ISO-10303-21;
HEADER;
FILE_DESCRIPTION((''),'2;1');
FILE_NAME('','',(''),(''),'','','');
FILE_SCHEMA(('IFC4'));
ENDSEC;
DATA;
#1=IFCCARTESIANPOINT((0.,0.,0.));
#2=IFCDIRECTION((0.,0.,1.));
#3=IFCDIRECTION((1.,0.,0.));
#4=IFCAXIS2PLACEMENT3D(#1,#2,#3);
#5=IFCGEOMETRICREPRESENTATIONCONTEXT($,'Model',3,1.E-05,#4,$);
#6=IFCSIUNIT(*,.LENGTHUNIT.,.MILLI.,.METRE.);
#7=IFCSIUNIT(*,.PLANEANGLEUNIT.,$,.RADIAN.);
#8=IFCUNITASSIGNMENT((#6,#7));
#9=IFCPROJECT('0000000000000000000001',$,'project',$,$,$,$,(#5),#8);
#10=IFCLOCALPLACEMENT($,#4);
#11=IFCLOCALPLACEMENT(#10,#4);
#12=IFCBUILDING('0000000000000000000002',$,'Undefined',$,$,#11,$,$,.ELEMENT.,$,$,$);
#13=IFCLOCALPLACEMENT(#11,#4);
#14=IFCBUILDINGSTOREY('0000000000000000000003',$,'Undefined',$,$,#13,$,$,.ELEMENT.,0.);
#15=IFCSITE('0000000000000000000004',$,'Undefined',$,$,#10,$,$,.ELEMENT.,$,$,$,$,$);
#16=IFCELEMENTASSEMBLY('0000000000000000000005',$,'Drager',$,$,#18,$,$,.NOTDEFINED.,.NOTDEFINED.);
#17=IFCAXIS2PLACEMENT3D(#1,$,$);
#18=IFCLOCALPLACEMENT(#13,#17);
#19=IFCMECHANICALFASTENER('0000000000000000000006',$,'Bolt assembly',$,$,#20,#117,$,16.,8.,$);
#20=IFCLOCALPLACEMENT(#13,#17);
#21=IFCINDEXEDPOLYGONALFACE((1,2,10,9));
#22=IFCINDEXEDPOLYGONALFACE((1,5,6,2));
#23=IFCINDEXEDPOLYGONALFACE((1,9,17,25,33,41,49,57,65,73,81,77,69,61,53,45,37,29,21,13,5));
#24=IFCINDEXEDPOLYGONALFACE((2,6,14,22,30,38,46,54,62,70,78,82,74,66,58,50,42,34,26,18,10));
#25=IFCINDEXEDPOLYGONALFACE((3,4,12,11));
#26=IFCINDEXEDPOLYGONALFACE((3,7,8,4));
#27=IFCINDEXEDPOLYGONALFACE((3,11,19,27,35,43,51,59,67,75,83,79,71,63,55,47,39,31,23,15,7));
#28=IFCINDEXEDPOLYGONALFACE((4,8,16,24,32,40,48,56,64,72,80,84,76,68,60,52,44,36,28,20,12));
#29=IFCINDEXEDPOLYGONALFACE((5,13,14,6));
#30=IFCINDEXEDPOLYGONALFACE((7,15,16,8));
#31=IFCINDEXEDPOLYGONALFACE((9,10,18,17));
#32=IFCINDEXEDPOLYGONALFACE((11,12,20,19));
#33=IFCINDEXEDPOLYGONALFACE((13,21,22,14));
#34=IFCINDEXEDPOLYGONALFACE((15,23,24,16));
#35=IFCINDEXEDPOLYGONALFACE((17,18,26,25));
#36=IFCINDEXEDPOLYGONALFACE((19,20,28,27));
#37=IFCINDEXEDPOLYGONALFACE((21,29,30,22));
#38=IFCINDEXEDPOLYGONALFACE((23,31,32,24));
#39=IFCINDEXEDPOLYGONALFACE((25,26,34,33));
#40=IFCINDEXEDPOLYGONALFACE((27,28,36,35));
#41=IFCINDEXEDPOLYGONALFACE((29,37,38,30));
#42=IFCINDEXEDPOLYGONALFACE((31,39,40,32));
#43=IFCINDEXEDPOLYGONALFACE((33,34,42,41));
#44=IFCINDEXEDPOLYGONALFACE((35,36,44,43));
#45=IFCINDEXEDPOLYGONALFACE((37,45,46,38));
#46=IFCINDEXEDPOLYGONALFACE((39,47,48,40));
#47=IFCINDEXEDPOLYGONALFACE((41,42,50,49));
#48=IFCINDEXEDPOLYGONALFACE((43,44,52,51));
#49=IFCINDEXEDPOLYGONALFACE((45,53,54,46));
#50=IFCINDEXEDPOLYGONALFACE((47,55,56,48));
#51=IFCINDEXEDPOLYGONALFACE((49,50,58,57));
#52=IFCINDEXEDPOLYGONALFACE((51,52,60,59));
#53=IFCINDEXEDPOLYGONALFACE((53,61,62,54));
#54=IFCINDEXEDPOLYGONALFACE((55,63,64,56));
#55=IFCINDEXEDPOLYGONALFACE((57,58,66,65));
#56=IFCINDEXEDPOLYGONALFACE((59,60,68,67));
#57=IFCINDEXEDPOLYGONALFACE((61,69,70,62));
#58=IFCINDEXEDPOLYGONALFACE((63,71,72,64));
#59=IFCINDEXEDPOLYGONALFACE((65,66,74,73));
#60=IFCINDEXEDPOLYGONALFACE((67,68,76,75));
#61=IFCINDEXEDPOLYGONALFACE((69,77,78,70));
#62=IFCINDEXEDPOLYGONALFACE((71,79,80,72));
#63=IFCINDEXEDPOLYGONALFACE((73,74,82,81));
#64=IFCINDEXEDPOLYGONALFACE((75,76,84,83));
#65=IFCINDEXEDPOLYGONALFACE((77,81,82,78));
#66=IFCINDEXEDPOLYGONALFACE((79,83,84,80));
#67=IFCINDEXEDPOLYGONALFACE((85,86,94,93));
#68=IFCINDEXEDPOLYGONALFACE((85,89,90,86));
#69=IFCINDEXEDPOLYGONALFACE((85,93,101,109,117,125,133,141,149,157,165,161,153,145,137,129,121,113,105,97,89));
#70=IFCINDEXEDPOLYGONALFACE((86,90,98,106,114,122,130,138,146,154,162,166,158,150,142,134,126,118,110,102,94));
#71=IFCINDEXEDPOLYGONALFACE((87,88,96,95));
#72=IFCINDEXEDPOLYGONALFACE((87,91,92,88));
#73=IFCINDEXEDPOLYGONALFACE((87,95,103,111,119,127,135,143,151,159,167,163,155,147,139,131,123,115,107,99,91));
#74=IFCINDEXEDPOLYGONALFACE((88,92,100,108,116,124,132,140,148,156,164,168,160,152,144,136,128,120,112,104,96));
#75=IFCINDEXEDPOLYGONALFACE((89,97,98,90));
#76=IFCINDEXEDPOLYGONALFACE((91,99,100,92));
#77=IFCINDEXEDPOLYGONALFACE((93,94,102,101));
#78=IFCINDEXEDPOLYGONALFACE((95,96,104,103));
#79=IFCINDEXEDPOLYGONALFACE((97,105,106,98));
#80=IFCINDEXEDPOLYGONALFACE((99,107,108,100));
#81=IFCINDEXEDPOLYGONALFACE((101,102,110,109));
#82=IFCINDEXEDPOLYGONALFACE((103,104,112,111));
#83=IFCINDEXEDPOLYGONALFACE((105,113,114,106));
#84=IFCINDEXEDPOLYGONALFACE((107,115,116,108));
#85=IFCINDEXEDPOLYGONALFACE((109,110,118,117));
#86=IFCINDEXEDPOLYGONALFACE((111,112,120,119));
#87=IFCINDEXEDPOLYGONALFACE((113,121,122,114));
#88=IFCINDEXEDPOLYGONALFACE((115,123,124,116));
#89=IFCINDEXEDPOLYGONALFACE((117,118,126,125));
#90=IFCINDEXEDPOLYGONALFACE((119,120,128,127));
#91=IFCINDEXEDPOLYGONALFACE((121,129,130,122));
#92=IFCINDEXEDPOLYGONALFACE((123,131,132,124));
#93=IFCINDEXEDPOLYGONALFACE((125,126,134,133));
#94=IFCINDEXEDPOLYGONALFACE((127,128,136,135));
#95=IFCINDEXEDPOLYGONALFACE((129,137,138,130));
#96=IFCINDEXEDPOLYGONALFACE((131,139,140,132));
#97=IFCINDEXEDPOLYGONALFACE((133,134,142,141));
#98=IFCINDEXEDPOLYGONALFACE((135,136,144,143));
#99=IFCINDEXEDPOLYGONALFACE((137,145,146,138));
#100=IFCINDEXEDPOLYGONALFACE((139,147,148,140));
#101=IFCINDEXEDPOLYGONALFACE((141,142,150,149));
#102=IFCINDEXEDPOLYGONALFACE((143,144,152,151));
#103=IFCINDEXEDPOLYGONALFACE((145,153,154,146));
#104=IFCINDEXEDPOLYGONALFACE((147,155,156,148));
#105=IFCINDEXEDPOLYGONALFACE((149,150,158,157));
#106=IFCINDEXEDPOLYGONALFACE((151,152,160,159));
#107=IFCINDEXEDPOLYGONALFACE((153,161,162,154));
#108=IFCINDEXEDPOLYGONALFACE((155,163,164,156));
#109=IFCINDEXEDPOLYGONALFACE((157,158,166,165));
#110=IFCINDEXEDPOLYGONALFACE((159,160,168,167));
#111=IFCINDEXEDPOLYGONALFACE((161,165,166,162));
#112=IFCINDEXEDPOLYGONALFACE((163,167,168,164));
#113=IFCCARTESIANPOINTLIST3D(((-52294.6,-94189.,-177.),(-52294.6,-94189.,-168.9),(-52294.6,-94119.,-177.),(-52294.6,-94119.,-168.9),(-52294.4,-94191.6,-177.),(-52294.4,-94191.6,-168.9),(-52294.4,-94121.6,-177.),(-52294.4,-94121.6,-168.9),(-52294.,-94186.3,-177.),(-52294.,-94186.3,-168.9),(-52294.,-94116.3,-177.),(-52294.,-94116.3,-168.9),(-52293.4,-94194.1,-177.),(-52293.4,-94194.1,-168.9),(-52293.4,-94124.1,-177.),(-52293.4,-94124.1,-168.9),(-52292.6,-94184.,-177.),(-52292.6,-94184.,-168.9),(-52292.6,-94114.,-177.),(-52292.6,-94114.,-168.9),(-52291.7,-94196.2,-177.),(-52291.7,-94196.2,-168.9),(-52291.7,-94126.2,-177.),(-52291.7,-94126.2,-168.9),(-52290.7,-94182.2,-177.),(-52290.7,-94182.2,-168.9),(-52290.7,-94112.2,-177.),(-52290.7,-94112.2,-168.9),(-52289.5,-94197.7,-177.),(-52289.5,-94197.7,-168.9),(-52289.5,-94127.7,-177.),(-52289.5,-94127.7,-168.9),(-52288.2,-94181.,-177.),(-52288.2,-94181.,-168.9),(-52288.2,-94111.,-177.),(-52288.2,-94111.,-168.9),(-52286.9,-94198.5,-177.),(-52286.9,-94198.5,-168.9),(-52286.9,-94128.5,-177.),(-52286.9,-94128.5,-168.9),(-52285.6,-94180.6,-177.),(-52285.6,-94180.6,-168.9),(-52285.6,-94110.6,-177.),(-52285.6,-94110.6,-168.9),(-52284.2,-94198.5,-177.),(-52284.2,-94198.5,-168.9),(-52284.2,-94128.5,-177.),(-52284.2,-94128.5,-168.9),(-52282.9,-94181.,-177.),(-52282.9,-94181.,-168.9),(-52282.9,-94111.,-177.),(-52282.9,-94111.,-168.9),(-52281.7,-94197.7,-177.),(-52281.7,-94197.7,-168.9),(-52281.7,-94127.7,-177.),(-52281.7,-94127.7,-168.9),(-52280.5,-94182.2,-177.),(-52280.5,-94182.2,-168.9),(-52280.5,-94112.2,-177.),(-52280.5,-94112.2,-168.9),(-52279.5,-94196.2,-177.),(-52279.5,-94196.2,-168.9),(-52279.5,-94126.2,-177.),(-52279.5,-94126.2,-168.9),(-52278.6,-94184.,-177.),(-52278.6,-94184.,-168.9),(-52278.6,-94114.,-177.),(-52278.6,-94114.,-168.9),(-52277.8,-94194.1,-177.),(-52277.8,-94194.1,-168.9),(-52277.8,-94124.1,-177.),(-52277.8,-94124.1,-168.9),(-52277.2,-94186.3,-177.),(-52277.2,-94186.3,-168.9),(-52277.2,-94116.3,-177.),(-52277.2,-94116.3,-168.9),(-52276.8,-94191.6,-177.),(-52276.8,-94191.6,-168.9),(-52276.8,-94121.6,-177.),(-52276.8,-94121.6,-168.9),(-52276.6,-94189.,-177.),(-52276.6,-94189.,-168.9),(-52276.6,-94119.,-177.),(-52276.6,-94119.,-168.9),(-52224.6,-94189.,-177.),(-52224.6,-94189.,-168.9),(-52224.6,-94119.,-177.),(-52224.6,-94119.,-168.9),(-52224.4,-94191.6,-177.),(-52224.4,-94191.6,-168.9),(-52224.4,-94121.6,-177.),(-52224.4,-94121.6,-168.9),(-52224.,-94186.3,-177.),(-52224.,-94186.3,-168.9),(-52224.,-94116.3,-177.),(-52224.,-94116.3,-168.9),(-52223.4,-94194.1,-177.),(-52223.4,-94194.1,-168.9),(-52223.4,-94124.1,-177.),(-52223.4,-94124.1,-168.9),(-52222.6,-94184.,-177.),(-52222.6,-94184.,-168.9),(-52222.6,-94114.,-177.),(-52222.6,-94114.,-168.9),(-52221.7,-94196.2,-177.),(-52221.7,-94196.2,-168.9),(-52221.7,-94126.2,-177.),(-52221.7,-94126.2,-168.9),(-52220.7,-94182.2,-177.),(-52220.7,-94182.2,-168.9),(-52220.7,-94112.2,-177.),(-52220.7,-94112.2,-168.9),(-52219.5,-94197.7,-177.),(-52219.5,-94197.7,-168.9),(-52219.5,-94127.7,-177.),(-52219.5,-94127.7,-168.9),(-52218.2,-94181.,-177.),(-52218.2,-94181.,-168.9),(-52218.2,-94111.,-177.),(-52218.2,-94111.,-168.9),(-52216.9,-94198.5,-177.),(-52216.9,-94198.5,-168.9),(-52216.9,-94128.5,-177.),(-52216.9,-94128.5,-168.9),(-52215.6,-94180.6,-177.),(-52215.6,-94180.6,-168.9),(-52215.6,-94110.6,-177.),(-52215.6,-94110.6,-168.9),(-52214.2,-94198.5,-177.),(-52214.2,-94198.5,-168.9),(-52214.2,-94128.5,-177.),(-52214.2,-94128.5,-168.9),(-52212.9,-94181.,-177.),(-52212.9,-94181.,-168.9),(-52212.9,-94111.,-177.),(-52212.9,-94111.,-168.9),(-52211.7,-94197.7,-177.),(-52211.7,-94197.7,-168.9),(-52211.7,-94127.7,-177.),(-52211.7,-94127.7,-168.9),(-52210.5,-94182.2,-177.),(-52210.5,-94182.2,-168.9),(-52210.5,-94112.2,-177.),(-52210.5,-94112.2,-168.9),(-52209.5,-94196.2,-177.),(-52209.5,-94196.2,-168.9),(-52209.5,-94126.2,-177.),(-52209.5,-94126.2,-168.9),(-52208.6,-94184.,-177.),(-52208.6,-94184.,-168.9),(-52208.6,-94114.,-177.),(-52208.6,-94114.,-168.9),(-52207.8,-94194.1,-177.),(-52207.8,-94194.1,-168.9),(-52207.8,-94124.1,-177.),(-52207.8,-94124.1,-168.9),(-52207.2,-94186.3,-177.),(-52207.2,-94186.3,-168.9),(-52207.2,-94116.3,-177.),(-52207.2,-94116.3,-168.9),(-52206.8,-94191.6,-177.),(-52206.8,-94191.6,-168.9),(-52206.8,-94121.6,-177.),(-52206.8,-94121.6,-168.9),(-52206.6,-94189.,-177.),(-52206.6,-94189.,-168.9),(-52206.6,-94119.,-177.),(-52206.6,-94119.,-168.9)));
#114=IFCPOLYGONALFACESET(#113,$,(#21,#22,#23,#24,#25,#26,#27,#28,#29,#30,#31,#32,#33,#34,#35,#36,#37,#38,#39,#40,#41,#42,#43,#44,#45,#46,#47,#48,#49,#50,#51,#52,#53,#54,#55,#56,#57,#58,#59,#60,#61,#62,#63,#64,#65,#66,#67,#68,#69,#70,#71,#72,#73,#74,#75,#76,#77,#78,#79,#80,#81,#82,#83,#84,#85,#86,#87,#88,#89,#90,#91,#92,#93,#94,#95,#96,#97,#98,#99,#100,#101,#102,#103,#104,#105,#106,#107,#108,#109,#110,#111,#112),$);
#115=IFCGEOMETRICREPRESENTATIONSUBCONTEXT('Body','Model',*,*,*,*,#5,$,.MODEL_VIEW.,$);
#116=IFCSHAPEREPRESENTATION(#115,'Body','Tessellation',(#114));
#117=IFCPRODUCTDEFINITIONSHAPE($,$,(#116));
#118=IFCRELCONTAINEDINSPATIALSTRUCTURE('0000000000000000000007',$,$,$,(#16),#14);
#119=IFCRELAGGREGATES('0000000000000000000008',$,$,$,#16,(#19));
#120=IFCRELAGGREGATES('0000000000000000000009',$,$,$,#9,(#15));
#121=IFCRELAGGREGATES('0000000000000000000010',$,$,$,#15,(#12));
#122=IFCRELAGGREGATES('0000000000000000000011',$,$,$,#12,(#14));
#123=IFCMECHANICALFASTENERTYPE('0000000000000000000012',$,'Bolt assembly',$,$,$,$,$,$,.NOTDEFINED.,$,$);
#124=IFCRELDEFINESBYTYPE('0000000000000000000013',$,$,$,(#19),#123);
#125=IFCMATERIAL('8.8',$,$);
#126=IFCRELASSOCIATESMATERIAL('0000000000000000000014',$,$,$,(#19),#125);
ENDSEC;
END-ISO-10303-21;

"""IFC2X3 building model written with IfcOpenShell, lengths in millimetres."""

from ifc_helpers import new_model, si_unit, frame, origin_with_axes, origin_2d_with_axis, place, context, subcontext, project, spatial, circle, extrude, source, transform, mapped, material, type_object, element, aggregate, save


model = new_model("IFC2X3")

# Units and contexts
model_context = context("Model", 3, precision=1e-05, world=origin_with_axes())
body_context = subcontext(model_context, "Body", "Model", "MODEL_VIEW")
ifc_project = project(units=[si_unit("LENGTHUNIT", "METRE", prefix="MILLI"), si_unit("PLANEANGLEUNIT", "RADIAN")], contexts=[model_context])

# Site, building, storey
site_placement = place(None, origin_with_axes())
site = spatial("IfcSite", under=ifc_project, at=site_placement, Name="Undefined", CompositionType="ELEMENT")
building_placement = place(site_placement, origin_with_axes())
building = spatial("IfcBuilding", under=site, at=building_placement, Name="Undefined", CompositionType="ELEMENT")
storey_placement = place(building_placement, origin_with_axes())
storey = spatial("IfcBuildingStorey", under=building, at=storey_placement, Name="Undefined", CompositionType="ELEMENT", Elevation=0.0)

# Element assembly, mechanical fastener
assembly_1_placement = place(storey_placement, origin_with_axes())
assembly_1 = element("IfcElementAssembly", 1, at=assembly_1_placement, inside=storey, Name="Drager", AssemblyPlace="NOTDEFINED", PredefinedType="NOTDEFINED")
ifc_material_1 = material(Name="8.8")
mechanical_fastener_type = type_object("IfcMechanicalFastenerType", Name="Bolt assembly")
shared_shape_1 = source(origin_with_axes(), body_context, "Body", "SweptSolid", [
    extrude(circle(Radius=9.0, at=origin_2d_with_axis()), frame((0.0, 0.0, 0.0), z_axis=(0.0, 1.0, 0.0), x_axis=(1.0, 0.0, 0.0)), (0.0, 0.0, 1.0), 8.1),
])
mechanical_fastener_1_placement = place(assembly_1_placement, frame((-52250.6, -94189.6, -177.0), z_axis=(1.0, 0.0, 0.0), x_axis=(0.0, 1.0, 0.0)))
mechanical_fastener_1 = element("IfcMechanicalFastener", 2, at=mechanical_fastener_1_placement, type_object=mechanical_fastener_type, material=ifc_material_1, Name="Bolt assembly", NominalDiameter=16.0, NominalLength=8.0, context=body_context, shape_type="MappedRepresentation", body=[
    mapped(shared_shape_1, transform((0.0, 0.0, -35.0))),
    mapped(shared_shape_1, transform((70.0, 0.0, -35.0))),
    mapped(shared_shape_1, transform((0.0, 0.0, 35.0))),
    mapped(shared_shape_1, transform((70.0, 0.0, 35.0))),
])
aggregate(assembly_1, [mechanical_fastener_1])

save(model, "model.ifc")
